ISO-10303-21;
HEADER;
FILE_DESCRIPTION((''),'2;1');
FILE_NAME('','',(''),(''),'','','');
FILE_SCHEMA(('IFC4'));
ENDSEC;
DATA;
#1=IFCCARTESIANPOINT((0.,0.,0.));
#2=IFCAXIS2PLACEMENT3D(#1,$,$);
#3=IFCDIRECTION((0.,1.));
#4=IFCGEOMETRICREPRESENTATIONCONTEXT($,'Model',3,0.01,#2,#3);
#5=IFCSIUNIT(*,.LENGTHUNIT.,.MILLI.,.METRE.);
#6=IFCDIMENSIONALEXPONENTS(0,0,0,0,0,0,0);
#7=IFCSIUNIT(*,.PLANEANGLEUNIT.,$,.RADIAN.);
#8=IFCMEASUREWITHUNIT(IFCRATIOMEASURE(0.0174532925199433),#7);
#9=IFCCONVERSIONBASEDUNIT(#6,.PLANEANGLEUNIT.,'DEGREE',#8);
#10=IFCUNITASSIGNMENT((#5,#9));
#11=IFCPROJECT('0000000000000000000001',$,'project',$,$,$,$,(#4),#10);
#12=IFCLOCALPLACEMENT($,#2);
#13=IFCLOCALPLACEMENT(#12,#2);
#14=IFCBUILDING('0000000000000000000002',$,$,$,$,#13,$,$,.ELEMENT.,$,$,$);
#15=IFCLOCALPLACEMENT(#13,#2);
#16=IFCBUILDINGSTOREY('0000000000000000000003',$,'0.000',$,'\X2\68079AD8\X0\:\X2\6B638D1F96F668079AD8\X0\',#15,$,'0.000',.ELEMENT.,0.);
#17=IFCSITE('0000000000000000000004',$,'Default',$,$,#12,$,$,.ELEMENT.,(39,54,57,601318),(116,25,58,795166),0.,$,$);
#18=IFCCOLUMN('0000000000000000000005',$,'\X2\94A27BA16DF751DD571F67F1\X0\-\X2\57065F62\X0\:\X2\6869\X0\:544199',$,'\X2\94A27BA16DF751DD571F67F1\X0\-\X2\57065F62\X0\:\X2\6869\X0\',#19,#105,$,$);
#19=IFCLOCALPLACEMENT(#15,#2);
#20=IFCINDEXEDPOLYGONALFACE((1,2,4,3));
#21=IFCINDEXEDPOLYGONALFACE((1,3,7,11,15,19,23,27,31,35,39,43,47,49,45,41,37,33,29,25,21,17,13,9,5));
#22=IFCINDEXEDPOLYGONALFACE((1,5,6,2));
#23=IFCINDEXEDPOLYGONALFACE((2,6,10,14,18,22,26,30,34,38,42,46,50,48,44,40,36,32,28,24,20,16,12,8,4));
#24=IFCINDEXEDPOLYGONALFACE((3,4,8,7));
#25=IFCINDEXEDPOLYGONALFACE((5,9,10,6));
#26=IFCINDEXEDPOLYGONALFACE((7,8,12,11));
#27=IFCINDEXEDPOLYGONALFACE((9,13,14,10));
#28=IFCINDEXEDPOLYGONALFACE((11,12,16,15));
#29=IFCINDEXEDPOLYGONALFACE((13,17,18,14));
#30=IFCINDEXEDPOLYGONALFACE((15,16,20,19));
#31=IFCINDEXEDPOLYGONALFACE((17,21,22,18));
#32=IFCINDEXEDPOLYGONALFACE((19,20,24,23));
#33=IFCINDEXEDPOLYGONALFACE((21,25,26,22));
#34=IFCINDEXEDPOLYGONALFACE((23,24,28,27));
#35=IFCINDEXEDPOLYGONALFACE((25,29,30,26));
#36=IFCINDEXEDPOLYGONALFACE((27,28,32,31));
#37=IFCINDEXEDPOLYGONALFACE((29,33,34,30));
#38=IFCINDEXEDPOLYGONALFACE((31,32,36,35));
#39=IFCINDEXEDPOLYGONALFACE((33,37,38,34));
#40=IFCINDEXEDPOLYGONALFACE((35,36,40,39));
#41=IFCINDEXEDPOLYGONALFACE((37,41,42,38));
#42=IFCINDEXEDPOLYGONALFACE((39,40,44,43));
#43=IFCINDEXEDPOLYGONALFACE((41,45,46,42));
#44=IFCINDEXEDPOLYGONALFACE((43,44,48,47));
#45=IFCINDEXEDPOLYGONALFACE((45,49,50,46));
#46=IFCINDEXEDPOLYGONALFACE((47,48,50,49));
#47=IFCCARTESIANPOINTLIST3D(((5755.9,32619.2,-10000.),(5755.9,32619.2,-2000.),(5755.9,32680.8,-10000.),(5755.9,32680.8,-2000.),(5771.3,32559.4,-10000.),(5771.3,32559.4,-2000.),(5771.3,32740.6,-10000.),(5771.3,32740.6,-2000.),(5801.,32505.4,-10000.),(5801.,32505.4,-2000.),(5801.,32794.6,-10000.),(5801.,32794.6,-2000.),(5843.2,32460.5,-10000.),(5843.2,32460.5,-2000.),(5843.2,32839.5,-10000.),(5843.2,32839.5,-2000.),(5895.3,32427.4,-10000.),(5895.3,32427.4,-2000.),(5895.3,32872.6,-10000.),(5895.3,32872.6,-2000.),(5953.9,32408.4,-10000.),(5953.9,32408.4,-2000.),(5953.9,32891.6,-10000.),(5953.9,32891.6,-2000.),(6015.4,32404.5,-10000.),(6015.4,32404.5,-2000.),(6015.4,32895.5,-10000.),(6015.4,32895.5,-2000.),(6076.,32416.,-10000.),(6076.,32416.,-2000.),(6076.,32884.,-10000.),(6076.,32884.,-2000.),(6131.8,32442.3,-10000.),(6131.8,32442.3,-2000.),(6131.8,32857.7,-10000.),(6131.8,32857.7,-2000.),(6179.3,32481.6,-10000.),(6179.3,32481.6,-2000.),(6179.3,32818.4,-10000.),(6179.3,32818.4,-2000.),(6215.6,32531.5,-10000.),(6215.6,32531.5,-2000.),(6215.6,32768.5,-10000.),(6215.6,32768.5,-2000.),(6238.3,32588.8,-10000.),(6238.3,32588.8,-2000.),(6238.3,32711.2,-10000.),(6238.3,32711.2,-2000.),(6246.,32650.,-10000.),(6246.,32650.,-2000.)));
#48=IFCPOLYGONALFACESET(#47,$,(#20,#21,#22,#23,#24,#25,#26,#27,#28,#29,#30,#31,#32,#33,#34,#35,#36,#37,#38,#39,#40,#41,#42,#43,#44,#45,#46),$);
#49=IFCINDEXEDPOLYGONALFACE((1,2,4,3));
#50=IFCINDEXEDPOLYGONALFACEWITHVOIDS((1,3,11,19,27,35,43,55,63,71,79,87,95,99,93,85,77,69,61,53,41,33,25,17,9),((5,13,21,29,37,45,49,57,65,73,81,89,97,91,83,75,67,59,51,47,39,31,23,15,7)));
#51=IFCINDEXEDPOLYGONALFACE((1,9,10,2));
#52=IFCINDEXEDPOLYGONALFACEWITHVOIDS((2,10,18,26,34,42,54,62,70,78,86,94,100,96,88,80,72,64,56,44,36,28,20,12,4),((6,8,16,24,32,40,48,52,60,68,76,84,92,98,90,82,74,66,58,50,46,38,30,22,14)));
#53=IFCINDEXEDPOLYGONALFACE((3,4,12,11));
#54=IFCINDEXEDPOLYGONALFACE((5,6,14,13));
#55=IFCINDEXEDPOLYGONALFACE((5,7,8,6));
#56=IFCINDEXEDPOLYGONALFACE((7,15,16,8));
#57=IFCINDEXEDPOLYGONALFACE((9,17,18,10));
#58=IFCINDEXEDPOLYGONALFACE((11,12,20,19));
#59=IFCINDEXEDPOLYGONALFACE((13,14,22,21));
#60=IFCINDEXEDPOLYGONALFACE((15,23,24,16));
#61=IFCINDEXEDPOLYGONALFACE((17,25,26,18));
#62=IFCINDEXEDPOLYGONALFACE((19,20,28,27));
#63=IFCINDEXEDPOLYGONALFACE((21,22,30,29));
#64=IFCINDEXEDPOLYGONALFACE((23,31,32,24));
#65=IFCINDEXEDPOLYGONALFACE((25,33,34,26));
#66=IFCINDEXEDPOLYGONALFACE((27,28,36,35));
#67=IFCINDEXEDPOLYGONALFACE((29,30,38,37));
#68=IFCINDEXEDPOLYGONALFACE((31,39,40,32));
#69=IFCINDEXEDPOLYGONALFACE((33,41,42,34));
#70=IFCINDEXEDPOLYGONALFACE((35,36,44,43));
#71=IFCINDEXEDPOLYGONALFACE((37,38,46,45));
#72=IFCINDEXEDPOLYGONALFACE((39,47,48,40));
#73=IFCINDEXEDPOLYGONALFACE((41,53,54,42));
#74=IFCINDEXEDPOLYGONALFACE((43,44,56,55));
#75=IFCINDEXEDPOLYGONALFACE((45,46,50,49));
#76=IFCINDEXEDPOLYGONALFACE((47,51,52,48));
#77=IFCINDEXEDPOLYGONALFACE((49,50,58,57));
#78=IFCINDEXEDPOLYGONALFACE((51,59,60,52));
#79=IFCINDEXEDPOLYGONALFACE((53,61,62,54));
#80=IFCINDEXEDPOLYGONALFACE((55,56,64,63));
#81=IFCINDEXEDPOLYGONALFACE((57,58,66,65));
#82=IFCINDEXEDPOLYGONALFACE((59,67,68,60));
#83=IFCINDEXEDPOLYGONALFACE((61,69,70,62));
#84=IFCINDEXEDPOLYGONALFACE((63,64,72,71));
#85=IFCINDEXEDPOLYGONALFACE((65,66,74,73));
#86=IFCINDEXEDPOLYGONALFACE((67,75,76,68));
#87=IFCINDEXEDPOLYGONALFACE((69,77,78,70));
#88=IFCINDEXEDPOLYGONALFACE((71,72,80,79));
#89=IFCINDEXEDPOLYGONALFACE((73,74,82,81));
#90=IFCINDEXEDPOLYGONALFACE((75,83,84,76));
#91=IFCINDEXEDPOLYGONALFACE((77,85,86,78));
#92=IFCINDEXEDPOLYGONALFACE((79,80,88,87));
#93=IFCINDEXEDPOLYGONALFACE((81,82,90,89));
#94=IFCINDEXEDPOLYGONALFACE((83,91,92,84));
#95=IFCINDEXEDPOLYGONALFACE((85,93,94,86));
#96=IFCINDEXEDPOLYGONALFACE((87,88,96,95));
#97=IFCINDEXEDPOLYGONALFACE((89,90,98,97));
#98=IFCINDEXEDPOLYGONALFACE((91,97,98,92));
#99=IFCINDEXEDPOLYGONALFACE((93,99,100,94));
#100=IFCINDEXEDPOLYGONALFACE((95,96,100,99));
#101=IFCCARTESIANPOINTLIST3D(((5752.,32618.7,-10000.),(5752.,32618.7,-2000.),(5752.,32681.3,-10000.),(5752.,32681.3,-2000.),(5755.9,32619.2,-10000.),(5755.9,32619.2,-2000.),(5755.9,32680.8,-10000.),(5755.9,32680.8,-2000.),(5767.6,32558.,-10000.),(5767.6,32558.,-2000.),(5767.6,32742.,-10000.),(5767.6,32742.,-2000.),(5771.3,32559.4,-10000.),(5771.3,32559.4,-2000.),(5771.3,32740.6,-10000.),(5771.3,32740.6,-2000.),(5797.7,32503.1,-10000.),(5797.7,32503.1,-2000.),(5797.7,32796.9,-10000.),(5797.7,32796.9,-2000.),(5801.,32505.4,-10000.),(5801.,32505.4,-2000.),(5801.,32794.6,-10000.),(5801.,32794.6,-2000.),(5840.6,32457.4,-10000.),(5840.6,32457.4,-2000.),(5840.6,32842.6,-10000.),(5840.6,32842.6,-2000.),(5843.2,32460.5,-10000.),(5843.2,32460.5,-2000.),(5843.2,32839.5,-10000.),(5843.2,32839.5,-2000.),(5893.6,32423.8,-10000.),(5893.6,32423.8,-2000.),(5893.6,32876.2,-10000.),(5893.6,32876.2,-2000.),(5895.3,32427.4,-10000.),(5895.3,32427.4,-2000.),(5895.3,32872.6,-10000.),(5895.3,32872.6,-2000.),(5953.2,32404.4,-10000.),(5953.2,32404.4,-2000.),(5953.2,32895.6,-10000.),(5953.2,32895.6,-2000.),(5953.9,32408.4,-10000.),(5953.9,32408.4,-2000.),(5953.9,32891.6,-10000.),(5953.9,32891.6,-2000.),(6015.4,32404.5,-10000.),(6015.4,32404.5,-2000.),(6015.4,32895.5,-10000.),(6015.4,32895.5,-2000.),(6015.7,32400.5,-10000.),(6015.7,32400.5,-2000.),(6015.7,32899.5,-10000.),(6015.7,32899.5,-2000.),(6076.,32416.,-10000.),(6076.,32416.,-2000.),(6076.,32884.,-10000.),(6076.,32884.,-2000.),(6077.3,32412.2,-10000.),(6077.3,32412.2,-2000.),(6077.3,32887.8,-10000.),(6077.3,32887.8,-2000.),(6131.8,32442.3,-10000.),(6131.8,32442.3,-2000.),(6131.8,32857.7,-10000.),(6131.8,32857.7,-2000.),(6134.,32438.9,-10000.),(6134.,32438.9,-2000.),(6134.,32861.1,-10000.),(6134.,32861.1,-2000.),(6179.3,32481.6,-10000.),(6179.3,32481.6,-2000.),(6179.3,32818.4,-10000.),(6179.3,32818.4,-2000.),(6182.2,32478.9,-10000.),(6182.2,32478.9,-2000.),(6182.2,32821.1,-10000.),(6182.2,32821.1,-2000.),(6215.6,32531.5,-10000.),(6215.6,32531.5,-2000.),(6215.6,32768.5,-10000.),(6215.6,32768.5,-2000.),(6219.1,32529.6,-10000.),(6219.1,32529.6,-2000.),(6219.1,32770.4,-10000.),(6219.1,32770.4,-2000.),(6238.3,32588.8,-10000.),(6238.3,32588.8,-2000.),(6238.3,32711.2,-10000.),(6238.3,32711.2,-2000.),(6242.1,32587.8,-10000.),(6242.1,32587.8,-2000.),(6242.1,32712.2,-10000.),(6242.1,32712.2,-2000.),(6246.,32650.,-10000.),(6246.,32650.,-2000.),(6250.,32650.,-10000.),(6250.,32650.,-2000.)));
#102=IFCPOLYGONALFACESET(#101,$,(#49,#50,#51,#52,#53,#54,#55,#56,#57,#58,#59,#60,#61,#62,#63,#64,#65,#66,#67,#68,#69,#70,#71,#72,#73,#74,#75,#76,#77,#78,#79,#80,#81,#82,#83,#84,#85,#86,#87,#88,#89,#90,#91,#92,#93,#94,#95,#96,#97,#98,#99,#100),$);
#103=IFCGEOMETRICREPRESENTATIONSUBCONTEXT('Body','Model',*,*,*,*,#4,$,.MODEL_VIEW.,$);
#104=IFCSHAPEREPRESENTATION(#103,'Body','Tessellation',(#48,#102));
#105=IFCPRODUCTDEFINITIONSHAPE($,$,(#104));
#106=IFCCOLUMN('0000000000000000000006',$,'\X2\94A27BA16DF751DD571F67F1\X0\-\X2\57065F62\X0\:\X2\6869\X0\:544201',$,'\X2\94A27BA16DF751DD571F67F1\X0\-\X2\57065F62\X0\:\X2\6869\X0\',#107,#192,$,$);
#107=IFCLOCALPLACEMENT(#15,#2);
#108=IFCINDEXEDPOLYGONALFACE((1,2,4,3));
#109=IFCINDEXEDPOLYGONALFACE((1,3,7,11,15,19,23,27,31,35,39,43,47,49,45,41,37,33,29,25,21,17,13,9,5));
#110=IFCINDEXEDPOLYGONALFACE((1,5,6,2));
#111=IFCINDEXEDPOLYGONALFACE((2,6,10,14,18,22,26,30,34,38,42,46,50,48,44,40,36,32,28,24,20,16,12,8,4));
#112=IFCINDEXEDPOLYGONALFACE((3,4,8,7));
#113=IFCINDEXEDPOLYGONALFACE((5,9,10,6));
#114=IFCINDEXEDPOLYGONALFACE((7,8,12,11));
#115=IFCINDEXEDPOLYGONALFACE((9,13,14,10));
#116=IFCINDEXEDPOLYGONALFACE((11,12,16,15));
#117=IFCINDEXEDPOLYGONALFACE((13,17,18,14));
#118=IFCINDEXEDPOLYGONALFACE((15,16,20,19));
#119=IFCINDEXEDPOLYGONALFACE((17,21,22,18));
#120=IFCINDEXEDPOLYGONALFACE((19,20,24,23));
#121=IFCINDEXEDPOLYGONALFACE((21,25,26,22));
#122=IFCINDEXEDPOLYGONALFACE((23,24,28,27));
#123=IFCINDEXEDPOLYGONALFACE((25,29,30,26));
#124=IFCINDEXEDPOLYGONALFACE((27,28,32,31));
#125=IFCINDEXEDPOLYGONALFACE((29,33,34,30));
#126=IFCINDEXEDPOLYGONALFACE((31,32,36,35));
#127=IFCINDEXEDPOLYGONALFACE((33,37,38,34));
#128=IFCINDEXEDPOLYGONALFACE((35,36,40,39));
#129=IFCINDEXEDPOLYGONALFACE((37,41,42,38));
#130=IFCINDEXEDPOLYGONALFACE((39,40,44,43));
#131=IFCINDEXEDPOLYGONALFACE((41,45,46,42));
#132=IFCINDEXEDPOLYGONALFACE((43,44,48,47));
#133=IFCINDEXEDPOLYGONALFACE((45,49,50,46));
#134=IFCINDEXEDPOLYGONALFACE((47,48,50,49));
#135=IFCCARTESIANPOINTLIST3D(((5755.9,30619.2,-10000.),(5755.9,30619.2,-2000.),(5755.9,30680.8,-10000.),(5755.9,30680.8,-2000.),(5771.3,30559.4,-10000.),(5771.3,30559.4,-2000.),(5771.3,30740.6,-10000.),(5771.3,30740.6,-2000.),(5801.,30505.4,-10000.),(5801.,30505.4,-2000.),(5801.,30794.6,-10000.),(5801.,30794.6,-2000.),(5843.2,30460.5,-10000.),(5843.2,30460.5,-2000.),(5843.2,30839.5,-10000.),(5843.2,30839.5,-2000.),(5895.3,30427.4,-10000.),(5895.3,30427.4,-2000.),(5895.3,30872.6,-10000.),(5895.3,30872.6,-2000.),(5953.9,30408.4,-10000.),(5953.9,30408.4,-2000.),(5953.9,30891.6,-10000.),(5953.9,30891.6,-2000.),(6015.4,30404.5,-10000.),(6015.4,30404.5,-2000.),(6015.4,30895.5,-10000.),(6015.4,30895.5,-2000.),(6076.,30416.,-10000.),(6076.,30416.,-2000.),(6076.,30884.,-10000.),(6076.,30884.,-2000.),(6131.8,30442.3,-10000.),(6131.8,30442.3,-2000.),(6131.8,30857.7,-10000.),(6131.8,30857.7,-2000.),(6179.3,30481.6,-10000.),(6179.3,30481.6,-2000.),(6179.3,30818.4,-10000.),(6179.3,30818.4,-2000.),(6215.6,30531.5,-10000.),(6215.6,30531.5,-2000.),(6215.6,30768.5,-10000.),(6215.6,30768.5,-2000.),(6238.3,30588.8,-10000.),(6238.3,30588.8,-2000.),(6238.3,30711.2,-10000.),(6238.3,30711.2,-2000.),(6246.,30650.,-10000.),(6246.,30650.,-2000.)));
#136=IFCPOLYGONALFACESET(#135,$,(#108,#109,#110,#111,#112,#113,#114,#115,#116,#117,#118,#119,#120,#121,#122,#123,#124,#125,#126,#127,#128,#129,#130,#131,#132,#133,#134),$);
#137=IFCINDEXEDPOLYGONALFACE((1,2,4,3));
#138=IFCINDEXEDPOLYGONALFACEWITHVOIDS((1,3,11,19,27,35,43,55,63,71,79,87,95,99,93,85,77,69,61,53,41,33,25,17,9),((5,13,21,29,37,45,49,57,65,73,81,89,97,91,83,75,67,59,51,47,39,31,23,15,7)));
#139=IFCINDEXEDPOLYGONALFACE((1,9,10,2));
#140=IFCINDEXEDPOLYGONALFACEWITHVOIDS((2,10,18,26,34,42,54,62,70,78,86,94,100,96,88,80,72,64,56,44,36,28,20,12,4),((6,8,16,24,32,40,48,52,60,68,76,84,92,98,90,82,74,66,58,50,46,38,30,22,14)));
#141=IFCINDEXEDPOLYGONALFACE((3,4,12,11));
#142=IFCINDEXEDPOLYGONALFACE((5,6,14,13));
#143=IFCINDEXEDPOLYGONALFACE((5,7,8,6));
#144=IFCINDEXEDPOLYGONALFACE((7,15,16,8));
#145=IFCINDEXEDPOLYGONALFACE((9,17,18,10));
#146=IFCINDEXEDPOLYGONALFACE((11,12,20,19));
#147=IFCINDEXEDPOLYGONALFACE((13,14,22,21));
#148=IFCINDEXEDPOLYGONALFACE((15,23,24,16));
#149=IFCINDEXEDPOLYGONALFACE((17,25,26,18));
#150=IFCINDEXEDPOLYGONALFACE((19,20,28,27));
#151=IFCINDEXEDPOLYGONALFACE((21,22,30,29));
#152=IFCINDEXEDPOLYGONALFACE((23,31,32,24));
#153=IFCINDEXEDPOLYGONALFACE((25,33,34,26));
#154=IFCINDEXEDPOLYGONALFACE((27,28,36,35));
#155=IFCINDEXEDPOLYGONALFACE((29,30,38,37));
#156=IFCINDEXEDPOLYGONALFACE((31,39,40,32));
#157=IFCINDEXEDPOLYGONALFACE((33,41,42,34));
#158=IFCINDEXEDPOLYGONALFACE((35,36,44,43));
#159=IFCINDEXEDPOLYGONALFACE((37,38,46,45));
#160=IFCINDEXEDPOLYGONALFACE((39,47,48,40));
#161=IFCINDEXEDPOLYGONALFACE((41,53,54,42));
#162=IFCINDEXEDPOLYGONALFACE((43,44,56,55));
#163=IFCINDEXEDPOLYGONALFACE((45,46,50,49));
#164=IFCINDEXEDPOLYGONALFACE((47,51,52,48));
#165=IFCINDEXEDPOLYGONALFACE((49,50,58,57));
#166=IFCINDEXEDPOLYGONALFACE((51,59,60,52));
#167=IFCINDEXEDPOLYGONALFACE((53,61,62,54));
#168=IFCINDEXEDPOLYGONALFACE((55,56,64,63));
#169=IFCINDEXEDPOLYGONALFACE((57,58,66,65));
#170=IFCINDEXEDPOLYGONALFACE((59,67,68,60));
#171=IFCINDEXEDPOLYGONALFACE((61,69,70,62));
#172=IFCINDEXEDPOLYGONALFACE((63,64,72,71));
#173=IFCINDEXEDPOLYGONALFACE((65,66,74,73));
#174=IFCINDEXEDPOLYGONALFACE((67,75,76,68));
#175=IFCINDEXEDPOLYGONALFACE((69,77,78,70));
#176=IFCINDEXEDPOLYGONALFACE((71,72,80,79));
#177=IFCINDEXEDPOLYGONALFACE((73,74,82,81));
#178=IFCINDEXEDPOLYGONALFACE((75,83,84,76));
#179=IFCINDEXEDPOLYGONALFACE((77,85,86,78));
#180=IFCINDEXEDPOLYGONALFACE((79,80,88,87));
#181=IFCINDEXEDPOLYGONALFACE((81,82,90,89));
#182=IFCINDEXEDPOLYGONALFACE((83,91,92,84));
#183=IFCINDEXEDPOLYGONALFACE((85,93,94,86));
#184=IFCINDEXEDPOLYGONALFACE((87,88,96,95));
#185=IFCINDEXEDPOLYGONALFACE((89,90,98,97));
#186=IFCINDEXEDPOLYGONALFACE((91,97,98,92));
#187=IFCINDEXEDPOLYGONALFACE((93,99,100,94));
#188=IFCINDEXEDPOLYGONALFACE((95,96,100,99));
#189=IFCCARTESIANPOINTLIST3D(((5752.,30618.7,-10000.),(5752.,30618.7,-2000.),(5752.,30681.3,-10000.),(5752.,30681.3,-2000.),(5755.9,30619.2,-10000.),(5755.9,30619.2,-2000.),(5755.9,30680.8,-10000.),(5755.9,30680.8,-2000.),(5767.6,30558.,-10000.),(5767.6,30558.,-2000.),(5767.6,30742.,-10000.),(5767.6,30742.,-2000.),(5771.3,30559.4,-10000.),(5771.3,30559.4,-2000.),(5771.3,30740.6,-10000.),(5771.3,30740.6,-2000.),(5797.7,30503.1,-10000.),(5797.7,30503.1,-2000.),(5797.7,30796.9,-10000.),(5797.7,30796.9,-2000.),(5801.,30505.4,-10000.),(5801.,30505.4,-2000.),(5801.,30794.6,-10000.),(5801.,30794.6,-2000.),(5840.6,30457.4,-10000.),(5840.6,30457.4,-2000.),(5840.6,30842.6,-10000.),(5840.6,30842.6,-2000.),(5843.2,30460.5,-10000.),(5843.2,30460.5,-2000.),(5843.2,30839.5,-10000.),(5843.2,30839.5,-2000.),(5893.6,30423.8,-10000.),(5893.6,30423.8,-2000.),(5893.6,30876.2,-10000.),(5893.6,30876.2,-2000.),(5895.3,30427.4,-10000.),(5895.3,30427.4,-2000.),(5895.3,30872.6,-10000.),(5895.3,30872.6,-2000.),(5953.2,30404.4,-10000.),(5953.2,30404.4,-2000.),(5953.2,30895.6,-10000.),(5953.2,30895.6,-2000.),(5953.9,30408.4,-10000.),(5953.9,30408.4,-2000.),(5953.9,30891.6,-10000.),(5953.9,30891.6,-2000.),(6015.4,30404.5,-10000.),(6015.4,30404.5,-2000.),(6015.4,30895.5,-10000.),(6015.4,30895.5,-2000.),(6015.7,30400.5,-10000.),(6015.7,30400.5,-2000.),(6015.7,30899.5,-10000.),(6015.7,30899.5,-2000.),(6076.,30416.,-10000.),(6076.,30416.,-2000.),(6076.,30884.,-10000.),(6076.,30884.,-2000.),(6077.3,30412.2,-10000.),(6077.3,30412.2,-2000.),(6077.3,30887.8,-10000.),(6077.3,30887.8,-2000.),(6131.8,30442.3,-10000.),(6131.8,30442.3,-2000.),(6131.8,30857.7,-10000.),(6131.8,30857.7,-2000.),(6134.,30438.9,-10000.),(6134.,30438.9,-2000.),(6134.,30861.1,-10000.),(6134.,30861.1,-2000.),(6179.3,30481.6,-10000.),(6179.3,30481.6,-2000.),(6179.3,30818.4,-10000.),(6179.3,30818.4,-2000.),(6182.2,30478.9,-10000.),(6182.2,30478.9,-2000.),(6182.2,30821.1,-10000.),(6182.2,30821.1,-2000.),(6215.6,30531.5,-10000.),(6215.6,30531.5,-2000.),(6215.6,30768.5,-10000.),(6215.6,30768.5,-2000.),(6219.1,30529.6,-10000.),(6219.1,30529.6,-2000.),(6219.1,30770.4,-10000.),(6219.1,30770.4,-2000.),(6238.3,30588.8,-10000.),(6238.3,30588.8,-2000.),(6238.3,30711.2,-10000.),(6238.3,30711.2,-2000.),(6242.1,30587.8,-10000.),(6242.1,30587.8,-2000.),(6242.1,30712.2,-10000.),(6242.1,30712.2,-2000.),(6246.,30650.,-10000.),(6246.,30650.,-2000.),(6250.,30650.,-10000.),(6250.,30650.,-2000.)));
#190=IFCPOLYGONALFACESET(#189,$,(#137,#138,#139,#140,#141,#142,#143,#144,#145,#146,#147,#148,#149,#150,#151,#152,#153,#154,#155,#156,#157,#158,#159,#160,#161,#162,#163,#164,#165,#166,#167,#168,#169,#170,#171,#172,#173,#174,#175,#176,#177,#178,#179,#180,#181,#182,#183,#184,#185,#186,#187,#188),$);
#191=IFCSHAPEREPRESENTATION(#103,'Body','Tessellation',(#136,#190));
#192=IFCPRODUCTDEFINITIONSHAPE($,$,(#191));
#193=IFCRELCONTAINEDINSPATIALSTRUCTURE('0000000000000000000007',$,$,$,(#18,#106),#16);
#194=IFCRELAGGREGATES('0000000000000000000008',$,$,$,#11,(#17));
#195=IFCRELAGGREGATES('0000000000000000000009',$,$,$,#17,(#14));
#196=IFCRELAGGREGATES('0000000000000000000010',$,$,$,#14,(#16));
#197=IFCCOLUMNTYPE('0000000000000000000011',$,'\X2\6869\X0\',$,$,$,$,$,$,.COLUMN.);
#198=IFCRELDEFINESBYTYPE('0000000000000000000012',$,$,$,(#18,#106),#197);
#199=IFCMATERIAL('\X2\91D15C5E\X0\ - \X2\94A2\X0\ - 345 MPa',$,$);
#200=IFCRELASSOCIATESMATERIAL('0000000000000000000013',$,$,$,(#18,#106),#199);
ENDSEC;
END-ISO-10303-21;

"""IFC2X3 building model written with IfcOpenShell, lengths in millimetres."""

from ifc_helpers import new_model, entity, si_unit, converted_unit, direction, frame, frame_2d, origin, place, context, subcontext, project, spatial, circle, hollow_circle, extrude, source, transform, mapped, material, type_object, type_shapes, element, save


model = new_model("IFC2X3")

# Units and contexts
model_context = context("Model", 3, precision=0.01, world=origin(), true_north=direction((0.0, 1.0)))
body_context = subcontext(model_context, "Body", "Model", "MODEL_VIEW")
ifc_project = project(units=[si_unit("LENGTHUNIT", "METRE", prefix="MILLI"), converted_unit("PLANEANGLEUNIT", "DEGREE", entity("IfcRatioMeasure", 0.0174532925199433), si_unit("PLANEANGLEUNIT", "RADIAN"), dimensions=[0, 0, 0, 0, 0, 0, 0])], contexts=[model_context])

# Site, building, storey
site_placement = place(None, origin())
site = spatial("IfcSite", under=ifc_project, at=site_placement, Name="Default", CompositionType="ELEMENT", RefLatitude=(39, 54, 57, 601318), RefLongitude=(116, 25, 58, 795166), RefElevation=0.0)
building_placement = place(site_placement, origin())
building = spatial("IfcBuilding", under=site, at=building_placement, CompositionType="ELEMENT")
storey_placement = place(building_placement, origin())
storey = spatial("IfcBuildingStorey", under=building, at=storey_placement, Name="0.000", ObjectType="标高:正负零标高", LongName="0.000", CompositionType="ELEMENT", Elevation=0.0)

# Columns
ifc_material_1 = material(Name="金属 - 钢 - 345 MPa")
column_type = type_object("IfcColumnType", Name="桩", PredefinedType="COLUMN")
shared_shape = source(origin(), body_context, "Body", "SweptSolid", [
    extrude(circle(Radius=246.0, at=frame_2d((0.0, 0.0), x_axis=(1.0, 0.0))), frame((0.0, 0.0, -10000.0)), (0.0, 0.0, 1.0), 8000.0),
    extrude(hollow_circle(Radius=250.0, WallThickness=4.0, at=frame_2d((0.0, 0.0), x_axis=(1.0, 0.0))), frame((0.0, 0.0, -10000.0)), (0.0, 0.0, 1.0), 8000.0),
])
type_shapes(column_type, [shared_shape])
for number, where, name in (
    (1, (6000.0, 32650.0, 0.0), "钢管混凝土柱-圆形:桩:544199"),
    (2, (6000.0, 30650.0, 0.0), "钢管混凝土柱-圆形:桩:544201"),
):
    element("IfcColumn", number, at=place(storey_placement, frame(where)), inside=storey, type_object=column_type, material=ifc_material_1, Name=name, ObjectType="钢管混凝土柱-圆形:桩", context=body_context, shape_type="MappedRepresentation", body=[
        mapped(shared_shape, transform((0.0, 0.0, 0.0), scale=1.0)),
    ])

save(model, "model.ifc")
